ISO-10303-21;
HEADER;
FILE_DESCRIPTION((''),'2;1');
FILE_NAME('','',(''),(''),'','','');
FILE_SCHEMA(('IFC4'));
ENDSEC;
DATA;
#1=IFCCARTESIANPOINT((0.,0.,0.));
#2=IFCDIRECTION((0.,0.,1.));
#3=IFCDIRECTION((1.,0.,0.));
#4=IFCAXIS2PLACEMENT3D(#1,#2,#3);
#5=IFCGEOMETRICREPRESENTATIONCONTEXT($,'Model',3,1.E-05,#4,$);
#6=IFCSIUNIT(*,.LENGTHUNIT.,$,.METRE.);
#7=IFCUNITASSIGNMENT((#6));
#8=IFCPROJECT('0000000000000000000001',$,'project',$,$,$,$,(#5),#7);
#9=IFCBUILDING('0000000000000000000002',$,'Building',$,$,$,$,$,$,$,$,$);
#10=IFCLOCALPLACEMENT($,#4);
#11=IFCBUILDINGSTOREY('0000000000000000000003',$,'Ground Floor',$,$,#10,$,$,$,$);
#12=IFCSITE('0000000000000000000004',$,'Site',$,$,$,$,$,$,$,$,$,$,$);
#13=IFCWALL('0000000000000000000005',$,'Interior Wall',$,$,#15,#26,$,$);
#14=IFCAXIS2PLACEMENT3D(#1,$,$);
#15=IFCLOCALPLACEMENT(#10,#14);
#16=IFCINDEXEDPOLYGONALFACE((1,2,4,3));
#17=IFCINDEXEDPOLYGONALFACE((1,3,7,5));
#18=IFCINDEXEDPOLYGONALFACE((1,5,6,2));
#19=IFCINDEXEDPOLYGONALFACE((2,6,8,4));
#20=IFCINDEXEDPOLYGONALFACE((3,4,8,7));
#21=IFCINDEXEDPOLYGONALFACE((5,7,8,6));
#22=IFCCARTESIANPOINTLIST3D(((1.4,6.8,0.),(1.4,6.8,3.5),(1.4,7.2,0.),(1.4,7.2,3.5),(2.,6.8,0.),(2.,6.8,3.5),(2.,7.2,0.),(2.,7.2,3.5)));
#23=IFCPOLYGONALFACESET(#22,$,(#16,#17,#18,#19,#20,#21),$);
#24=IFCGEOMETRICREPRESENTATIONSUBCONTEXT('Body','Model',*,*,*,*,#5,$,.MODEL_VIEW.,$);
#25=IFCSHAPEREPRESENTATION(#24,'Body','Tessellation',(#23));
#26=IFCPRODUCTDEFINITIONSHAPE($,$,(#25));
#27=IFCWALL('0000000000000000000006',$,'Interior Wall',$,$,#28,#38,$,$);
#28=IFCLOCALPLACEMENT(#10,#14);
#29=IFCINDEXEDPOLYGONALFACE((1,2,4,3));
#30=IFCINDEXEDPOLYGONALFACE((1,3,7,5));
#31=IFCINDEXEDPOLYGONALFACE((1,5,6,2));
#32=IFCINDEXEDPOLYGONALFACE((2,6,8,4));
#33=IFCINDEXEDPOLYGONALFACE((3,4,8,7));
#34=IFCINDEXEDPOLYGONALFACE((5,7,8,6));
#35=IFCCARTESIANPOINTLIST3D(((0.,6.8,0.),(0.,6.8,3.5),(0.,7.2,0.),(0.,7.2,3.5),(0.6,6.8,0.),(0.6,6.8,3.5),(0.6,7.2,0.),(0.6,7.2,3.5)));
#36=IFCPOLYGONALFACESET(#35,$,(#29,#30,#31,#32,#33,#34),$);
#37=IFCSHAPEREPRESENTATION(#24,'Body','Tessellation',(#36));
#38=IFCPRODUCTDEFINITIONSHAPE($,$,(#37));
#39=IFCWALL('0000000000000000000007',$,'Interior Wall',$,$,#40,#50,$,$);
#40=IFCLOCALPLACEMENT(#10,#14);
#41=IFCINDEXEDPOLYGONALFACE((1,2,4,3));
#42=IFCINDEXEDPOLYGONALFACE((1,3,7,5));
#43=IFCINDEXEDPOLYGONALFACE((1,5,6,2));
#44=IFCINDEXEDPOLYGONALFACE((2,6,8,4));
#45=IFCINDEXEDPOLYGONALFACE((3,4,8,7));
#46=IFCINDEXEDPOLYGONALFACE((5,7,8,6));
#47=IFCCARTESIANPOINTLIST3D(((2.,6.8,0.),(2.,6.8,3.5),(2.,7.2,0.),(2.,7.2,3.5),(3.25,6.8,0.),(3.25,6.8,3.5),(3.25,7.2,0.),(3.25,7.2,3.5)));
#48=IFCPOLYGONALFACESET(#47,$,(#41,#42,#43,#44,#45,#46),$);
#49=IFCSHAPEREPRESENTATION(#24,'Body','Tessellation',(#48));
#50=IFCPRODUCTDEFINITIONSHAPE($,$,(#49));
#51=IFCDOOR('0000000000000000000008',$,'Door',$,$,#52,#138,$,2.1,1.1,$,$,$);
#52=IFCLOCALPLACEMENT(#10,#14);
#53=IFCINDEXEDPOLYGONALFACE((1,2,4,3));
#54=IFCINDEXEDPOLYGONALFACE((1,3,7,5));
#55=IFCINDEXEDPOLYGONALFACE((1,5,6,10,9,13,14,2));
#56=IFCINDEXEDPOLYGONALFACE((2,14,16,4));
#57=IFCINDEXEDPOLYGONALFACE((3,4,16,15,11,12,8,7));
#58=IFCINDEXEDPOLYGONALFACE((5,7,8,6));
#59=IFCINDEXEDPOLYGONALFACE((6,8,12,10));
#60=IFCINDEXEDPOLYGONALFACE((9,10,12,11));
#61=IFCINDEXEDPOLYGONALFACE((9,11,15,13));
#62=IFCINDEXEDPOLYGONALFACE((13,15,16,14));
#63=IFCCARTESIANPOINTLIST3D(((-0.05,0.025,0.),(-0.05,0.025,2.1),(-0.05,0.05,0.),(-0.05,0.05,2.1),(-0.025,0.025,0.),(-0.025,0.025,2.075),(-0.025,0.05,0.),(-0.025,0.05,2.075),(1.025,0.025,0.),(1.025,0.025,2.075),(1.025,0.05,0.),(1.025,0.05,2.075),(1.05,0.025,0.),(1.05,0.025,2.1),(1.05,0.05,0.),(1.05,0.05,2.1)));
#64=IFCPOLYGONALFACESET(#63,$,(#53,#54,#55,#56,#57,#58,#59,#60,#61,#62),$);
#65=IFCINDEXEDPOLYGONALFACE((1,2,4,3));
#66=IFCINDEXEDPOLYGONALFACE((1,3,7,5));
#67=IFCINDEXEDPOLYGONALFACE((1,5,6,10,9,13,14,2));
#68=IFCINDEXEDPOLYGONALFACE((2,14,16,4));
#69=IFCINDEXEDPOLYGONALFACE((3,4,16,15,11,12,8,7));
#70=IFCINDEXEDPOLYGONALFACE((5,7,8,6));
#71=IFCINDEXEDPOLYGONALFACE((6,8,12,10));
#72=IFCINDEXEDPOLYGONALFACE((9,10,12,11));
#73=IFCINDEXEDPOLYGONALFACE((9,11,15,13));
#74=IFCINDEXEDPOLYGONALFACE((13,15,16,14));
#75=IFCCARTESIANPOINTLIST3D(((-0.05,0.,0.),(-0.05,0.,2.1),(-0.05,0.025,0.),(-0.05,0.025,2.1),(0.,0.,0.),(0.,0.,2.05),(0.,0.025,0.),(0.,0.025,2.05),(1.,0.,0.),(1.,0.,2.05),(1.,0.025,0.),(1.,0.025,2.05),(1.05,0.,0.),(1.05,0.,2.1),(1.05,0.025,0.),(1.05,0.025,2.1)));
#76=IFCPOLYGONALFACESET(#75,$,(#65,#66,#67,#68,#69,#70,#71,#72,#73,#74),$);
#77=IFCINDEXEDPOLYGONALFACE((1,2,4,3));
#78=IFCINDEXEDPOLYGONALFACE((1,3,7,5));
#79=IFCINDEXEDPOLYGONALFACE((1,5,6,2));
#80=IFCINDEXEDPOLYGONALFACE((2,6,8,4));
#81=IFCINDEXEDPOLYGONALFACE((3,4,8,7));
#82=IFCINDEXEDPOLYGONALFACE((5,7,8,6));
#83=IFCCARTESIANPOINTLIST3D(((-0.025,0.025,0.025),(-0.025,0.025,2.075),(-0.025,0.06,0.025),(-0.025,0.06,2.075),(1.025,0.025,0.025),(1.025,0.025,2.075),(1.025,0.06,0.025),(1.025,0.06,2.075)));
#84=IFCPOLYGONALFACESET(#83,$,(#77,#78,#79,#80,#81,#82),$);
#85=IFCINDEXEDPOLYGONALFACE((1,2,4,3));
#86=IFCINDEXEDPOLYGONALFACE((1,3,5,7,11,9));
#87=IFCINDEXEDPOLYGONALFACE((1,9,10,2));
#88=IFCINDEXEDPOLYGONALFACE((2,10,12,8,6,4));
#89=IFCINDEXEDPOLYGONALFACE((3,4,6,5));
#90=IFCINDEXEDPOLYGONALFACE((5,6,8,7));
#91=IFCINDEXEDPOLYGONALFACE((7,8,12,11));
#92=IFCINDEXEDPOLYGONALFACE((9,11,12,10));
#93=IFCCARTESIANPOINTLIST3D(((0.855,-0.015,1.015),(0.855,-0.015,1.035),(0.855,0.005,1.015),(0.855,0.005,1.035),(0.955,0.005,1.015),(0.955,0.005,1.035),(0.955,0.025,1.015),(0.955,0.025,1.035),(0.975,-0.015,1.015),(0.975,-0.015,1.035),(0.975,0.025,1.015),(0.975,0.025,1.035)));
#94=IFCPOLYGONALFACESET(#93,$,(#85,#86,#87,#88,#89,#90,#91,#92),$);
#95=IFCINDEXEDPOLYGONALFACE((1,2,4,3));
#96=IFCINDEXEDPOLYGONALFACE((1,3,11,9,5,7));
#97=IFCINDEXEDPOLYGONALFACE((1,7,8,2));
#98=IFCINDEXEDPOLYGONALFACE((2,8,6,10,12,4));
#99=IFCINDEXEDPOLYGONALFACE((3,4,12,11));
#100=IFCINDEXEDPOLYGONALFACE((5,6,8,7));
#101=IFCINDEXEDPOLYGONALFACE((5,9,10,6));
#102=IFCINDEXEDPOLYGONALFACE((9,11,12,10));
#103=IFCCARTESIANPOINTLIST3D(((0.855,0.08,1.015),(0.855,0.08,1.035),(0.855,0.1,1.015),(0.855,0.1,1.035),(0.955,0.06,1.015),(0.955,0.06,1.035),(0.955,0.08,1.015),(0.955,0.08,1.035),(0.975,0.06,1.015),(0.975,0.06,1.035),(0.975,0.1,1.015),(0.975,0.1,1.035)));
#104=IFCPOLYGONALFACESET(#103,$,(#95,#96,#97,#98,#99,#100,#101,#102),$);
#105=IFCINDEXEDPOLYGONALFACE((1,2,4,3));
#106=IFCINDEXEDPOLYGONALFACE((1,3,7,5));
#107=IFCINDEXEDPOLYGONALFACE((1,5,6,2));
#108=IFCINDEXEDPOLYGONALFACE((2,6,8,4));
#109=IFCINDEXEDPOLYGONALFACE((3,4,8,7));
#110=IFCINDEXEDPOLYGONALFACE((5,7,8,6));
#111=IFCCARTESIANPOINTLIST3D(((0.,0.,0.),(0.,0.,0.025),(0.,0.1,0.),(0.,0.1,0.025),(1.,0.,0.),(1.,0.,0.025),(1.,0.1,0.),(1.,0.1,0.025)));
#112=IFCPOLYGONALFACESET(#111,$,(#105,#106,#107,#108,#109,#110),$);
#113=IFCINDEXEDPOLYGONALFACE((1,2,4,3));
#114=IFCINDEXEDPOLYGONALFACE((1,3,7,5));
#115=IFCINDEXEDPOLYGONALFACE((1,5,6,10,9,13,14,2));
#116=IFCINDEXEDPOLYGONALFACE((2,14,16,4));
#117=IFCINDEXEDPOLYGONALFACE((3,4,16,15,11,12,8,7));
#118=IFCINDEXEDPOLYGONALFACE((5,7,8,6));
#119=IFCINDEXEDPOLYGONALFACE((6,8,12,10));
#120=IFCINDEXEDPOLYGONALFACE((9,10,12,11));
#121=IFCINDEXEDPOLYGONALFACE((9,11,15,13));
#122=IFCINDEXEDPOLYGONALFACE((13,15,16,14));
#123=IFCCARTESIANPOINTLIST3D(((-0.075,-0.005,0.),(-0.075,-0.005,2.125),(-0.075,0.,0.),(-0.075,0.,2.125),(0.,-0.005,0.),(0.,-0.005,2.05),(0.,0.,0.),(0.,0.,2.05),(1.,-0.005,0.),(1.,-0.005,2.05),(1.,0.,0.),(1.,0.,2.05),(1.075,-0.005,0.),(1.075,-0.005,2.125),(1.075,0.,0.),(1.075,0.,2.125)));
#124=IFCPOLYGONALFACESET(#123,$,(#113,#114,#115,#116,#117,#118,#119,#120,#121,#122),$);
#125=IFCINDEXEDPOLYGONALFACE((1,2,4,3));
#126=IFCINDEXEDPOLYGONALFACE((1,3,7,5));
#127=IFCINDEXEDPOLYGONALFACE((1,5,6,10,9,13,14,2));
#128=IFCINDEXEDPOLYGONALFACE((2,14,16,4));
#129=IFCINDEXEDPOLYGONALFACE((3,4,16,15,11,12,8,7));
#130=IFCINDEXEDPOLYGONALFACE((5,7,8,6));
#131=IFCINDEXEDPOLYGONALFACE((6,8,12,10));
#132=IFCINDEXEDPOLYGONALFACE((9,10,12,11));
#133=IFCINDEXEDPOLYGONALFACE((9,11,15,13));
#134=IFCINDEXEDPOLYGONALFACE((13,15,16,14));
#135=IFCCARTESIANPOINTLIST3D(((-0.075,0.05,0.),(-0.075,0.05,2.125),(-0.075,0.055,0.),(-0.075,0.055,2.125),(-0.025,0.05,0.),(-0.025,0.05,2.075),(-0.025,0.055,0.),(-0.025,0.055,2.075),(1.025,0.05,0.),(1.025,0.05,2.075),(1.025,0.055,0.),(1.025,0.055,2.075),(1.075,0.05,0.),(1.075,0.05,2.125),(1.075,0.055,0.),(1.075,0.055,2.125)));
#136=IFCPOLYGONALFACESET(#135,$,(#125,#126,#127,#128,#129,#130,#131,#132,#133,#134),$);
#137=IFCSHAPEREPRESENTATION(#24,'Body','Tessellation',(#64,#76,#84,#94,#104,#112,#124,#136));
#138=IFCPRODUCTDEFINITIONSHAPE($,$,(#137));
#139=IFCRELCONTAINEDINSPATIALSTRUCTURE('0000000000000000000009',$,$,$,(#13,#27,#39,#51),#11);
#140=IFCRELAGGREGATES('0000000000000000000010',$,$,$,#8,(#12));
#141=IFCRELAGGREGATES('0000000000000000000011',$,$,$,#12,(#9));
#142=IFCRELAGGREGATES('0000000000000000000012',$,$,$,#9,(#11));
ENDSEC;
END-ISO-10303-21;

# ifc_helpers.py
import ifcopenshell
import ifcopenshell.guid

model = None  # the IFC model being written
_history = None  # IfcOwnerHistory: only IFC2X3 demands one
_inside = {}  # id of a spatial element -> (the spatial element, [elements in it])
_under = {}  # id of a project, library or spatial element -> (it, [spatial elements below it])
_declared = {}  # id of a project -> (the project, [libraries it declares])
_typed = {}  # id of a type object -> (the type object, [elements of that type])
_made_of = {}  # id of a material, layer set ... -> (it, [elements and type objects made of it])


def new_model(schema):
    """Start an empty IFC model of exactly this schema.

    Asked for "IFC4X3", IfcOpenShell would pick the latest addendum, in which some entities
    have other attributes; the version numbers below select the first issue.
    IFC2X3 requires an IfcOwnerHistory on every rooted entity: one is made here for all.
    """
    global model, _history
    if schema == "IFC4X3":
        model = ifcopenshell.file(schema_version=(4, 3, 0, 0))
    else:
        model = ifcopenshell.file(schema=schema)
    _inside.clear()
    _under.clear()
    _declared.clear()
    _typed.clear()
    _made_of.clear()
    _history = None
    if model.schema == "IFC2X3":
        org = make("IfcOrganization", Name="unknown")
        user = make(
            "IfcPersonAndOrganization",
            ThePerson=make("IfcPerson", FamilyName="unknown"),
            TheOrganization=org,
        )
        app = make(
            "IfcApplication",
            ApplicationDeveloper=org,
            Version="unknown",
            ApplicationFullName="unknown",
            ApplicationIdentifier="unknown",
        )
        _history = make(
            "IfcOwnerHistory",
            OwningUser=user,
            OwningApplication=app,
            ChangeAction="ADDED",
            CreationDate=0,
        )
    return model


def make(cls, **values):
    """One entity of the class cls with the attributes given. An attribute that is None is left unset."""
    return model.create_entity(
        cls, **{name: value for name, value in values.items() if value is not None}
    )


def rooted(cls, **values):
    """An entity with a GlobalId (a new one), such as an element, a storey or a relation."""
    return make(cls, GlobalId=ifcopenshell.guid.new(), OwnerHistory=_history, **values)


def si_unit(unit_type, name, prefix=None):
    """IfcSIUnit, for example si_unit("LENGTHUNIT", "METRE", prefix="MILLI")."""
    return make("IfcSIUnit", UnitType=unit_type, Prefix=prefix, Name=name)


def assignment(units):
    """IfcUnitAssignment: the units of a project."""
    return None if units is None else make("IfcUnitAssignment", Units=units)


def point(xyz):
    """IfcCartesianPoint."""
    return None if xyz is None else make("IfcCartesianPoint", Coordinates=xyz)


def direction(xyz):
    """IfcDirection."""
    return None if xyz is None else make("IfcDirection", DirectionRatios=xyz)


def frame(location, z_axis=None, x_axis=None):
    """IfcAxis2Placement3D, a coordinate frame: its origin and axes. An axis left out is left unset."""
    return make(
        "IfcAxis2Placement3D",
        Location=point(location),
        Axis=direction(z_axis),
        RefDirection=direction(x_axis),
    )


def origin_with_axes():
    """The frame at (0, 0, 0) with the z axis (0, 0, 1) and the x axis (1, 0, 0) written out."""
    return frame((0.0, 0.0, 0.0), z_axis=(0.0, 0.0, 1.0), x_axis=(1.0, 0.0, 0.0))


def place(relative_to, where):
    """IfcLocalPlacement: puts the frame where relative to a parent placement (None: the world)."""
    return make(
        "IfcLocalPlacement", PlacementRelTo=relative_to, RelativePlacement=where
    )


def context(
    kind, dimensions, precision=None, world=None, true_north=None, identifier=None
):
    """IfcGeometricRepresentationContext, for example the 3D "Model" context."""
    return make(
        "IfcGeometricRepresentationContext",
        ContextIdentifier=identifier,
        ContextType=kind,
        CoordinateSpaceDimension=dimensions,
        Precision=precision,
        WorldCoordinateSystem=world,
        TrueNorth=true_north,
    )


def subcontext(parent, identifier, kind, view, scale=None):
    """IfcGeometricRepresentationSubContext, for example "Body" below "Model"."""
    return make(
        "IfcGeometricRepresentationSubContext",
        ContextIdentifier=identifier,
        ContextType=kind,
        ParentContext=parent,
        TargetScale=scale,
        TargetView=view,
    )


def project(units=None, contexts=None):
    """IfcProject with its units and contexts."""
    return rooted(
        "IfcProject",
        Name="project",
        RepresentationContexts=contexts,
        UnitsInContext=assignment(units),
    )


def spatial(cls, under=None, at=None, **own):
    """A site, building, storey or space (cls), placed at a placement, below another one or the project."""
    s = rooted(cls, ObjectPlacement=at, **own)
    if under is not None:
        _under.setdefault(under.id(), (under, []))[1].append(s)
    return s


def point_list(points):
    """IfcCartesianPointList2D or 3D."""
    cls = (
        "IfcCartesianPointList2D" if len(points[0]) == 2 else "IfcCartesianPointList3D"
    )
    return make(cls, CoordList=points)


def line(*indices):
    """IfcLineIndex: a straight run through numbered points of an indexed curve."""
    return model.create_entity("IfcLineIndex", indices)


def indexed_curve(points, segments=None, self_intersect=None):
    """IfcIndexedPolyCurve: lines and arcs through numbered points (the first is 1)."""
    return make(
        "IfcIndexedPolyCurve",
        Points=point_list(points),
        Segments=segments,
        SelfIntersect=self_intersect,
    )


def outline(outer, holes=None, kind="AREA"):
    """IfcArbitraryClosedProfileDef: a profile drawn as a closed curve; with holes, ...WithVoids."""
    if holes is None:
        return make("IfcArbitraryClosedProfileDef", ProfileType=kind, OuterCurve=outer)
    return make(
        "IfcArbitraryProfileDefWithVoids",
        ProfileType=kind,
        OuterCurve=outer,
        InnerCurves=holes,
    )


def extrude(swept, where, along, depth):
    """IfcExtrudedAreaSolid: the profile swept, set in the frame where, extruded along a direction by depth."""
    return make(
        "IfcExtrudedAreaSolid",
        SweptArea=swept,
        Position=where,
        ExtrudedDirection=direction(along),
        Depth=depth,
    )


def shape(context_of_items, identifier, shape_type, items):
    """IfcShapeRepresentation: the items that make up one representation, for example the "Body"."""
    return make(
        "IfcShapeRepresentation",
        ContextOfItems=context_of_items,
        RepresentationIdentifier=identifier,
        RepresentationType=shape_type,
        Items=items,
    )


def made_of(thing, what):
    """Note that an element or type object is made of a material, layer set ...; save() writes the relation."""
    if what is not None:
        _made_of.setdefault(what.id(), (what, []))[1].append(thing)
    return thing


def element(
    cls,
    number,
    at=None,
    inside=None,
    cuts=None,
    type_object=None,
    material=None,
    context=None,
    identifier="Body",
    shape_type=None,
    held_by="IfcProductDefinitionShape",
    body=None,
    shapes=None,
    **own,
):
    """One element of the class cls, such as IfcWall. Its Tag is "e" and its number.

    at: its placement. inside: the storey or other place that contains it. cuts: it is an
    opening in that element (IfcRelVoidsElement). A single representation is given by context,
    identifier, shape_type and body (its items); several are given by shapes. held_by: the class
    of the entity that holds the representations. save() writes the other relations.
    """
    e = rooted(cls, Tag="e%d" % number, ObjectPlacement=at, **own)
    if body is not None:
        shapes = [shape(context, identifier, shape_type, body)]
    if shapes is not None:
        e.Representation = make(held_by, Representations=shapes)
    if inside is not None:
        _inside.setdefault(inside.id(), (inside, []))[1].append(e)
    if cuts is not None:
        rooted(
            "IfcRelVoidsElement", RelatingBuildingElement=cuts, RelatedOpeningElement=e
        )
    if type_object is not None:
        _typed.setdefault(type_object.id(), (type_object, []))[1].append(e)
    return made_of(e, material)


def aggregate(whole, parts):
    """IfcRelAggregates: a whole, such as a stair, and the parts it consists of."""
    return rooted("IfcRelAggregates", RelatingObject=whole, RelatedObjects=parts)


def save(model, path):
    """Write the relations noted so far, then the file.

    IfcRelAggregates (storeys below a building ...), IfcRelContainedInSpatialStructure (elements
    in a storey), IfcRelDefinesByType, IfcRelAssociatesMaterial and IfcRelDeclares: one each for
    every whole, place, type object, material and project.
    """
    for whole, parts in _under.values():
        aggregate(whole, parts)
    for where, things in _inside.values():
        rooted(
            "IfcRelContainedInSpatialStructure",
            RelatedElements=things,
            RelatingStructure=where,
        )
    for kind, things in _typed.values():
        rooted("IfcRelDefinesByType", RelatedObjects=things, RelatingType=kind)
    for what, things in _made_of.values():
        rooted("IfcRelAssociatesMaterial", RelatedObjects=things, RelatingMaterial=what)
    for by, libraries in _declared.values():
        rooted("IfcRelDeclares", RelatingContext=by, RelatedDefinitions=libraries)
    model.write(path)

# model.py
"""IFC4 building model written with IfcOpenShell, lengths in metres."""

from ifc_helpers import new_model, si_unit, frame, origin_with_axes, place, context, subcontext, project, spatial, line, indexed_curve, outline, extrude, element, save


model = new_model("IFC4")

# Units and contexts
model_context = context("Model", 3, precision=1e-05, world=origin_with_axes())
body_context = subcontext(model_context, "Body", "Model", "MODEL_VIEW")
ifc_project = project(units=[si_unit("LENGTHUNIT", "METRE")], contexts=[model_context])

# Site, building, storey
site = spatial("IfcSite", under=ifc_project, Name="Site")
building = spatial("IfcBuilding", under=site, Name="Building")
storey_placement = place(None, origin_with_axes())
storey = spatial("IfcBuildingStorey", under=building, at=storey_placement, Name="Ground Floor")

# Walls
for number, where, z_axis, x_axis, name in (
    (1, (2.0, 7.0, 0.0), (0.0, 0.0, 1.0), (-1.0, 0.0, 0.0), "Interior Wall"),
    (2, (0.6, 7.0, 0.0), (0.0, 0.0, 1.0), (-1.0, 0.0, 0.0), "Interior Wall"),
):
    element("IfcWall", number, at=place(storey_placement, frame(where, z_axis=z_axis, x_axis=x_axis)), inside=storey, Name=name, context=body_context, shape_type="SweptSolid", body=[
        extrude(outline(indexed_curve([(0.0, 0.0), (0.0, 0.4), (0.6, 0.4), (0.6, 0.0), (0.0, 0.0)], self_intersect=False)), frame((0.0, -0.2, 0.0), z_axis=(0.0, 0.0, 1.0), x_axis=(1.0, 0.0, 0.0)), (0.0, 0.0, 1.0), 3.5),
    ])
wall_1_placement = place(storey_placement, frame((3.25, 7.0, 0.0), z_axis=(0.0, 0.0, 1.0), x_axis=(-1.0, 0.0, 0.0)))
element("IfcWall", 3, at=wall_1_placement, inside=storey, Name="Interior Wall", context=body_context, shape_type="SweptSolid", body=[
    extrude(outline(indexed_curve([(0.0, 0.0), (0.0, 0.4), (1.25, 0.4), (1.25, 0.0), (0.0, 0.0)], self_intersect=False)), frame((0.0, -0.2, 0.0), z_axis=(0.0, 0.0, 1.0), x_axis=(1.0, 0.0, 0.0)), (0.0, 0.0, 1.0), 3.5),
])

# Door
door_1_placement = place(storey_placement, frame((-0.05, 0.0, 0.0), z_axis=(0.0, 0.0, 1.0), x_axis=(1.0, 0.0, 0.0)))
element("IfcDoor", 4, at=door_1_placement, inside=storey, Name="Door", OverallHeight=2.1, OverallWidth=1.1, context=body_context, shape_type="SweptSolid", body=[
    extrude(outline(indexed_curve([(0.0, 0.0), (0.0, 2.1), (1.1, 2.1), (1.1, 0.0), (1.075, 0.0), (1.075, 2.075), (0.025, 2.075), (0.025, 0.0)], segments=[line(1, 2, 3, 4, 5, 6, 7, 8, 1)])), frame((0.0, 0.025, 0.0), z_axis=(0.0, -1.0, 0.0), x_axis=(1.0, 0.0, 0.0)), (0.0, 0.0, -1.0), 0.025),
    extrude(outline(indexed_curve([(0.0, 0.0), (0.0, 2.1), (1.1, 2.1), (1.1, 0.0), (1.05, 0.0), (1.05, 2.05), (0.05, 2.05), (0.05, 0.0)], segments=[line(1, 2, 3, 4, 5, 6, 7, 8, 1)])), frame((0.0, 0.0, 0.0), z_axis=(0.0, -1.0, 0.0), x_axis=(1.0, 0.0, 0.0)), (0.0, 0.0, -1.0), 0.025),
    extrude(outline(indexed_curve([(0.0, 0.0), (1.05, 0.0), (1.05, 0.035), (0.0, 0.035)], segments=[line(1, 2, 3, 4, 1)])), frame((0.025, 0.025, 0.025), z_axis=(0.0, 0.0, 1.0), x_axis=(1.0, 0.0, 0.0)), (0.0, 0.0, 1.0), 2.05),
    extrude(outline(indexed_curve([(0.0, 0.0), (0.0, -0.04), (-0.12, -0.04), (-0.12, -0.02), (-0.02, -0.02), (-0.02, 0.0)], segments=[line(1, 2, 3, 4, 5, 6, 1)])), frame((1.025, 0.025, 1.015), z_axis=(0.0, 0.0, 1.0), x_axis=(1.0, 0.0, 0.0)), (0.0, 0.0, 1.0), 0.02),
    extrude(outline(indexed_curve([(0.0, 0.0), (0.0, 0.04), (-0.12, 0.04), (-0.12, 0.02), (-0.02, 0.02), (-0.02, 0.0)], segments=[line(1, 2, 3, 4, 5, 6, 1)])), frame((1.025, 0.06, 1.015), z_axis=(0.0, 0.0, 1.0), x_axis=(1.0, 0.0, 0.0)), (0.0, 0.0, 1.0), 0.02),
    extrude(outline(indexed_curve([(0.0, 0.0), (1.0, 0.0), (1.0, 0.1), (0.0, 0.1)], segments=[line(1, 2, 3, 4, 1)])), frame((0.05, 0.0, 0.0), z_axis=(0.0, 0.0, 1.0), x_axis=(1.0, 0.0, 0.0)), (0.0, 0.0, 1.0), 0.025),
    extrude(outline(indexed_curve([(0.0, 0.0), (0.0, 2.125), (1.15, 2.125), (1.15, 0.0), (1.075, 0.0), (1.075, 2.05), (0.075, 2.05), (0.075, 0.0)], segments=[line(1, 2, 3, 4, 5, 6, 7, 8, 1)])), frame((-0.025, -0.005, 0.0), z_axis=(0.0, -1.0, 0.0), x_axis=(1.0, 0.0, 0.0)), (0.0, 0.0, -1.0), 0.005),
    extrude(outline(indexed_curve([(0.0, 0.0), (0.0, 2.125), (1.15, 2.125), (1.15, 0.0), (1.1, 0.0), (1.1, 2.075), (0.05, 2.075), (0.05, 0.0)], segments=[line(1, 2, 3, 4, 5, 6, 7, 8, 1)])), frame((-0.025, 0.05, 0.0), z_axis=(0.0, -1.0, 0.0), x_axis=(1.0, 0.0, 0.0)), (0.0, 0.0, -1.0), 0.005),
])

save(model, "model.ifc")
